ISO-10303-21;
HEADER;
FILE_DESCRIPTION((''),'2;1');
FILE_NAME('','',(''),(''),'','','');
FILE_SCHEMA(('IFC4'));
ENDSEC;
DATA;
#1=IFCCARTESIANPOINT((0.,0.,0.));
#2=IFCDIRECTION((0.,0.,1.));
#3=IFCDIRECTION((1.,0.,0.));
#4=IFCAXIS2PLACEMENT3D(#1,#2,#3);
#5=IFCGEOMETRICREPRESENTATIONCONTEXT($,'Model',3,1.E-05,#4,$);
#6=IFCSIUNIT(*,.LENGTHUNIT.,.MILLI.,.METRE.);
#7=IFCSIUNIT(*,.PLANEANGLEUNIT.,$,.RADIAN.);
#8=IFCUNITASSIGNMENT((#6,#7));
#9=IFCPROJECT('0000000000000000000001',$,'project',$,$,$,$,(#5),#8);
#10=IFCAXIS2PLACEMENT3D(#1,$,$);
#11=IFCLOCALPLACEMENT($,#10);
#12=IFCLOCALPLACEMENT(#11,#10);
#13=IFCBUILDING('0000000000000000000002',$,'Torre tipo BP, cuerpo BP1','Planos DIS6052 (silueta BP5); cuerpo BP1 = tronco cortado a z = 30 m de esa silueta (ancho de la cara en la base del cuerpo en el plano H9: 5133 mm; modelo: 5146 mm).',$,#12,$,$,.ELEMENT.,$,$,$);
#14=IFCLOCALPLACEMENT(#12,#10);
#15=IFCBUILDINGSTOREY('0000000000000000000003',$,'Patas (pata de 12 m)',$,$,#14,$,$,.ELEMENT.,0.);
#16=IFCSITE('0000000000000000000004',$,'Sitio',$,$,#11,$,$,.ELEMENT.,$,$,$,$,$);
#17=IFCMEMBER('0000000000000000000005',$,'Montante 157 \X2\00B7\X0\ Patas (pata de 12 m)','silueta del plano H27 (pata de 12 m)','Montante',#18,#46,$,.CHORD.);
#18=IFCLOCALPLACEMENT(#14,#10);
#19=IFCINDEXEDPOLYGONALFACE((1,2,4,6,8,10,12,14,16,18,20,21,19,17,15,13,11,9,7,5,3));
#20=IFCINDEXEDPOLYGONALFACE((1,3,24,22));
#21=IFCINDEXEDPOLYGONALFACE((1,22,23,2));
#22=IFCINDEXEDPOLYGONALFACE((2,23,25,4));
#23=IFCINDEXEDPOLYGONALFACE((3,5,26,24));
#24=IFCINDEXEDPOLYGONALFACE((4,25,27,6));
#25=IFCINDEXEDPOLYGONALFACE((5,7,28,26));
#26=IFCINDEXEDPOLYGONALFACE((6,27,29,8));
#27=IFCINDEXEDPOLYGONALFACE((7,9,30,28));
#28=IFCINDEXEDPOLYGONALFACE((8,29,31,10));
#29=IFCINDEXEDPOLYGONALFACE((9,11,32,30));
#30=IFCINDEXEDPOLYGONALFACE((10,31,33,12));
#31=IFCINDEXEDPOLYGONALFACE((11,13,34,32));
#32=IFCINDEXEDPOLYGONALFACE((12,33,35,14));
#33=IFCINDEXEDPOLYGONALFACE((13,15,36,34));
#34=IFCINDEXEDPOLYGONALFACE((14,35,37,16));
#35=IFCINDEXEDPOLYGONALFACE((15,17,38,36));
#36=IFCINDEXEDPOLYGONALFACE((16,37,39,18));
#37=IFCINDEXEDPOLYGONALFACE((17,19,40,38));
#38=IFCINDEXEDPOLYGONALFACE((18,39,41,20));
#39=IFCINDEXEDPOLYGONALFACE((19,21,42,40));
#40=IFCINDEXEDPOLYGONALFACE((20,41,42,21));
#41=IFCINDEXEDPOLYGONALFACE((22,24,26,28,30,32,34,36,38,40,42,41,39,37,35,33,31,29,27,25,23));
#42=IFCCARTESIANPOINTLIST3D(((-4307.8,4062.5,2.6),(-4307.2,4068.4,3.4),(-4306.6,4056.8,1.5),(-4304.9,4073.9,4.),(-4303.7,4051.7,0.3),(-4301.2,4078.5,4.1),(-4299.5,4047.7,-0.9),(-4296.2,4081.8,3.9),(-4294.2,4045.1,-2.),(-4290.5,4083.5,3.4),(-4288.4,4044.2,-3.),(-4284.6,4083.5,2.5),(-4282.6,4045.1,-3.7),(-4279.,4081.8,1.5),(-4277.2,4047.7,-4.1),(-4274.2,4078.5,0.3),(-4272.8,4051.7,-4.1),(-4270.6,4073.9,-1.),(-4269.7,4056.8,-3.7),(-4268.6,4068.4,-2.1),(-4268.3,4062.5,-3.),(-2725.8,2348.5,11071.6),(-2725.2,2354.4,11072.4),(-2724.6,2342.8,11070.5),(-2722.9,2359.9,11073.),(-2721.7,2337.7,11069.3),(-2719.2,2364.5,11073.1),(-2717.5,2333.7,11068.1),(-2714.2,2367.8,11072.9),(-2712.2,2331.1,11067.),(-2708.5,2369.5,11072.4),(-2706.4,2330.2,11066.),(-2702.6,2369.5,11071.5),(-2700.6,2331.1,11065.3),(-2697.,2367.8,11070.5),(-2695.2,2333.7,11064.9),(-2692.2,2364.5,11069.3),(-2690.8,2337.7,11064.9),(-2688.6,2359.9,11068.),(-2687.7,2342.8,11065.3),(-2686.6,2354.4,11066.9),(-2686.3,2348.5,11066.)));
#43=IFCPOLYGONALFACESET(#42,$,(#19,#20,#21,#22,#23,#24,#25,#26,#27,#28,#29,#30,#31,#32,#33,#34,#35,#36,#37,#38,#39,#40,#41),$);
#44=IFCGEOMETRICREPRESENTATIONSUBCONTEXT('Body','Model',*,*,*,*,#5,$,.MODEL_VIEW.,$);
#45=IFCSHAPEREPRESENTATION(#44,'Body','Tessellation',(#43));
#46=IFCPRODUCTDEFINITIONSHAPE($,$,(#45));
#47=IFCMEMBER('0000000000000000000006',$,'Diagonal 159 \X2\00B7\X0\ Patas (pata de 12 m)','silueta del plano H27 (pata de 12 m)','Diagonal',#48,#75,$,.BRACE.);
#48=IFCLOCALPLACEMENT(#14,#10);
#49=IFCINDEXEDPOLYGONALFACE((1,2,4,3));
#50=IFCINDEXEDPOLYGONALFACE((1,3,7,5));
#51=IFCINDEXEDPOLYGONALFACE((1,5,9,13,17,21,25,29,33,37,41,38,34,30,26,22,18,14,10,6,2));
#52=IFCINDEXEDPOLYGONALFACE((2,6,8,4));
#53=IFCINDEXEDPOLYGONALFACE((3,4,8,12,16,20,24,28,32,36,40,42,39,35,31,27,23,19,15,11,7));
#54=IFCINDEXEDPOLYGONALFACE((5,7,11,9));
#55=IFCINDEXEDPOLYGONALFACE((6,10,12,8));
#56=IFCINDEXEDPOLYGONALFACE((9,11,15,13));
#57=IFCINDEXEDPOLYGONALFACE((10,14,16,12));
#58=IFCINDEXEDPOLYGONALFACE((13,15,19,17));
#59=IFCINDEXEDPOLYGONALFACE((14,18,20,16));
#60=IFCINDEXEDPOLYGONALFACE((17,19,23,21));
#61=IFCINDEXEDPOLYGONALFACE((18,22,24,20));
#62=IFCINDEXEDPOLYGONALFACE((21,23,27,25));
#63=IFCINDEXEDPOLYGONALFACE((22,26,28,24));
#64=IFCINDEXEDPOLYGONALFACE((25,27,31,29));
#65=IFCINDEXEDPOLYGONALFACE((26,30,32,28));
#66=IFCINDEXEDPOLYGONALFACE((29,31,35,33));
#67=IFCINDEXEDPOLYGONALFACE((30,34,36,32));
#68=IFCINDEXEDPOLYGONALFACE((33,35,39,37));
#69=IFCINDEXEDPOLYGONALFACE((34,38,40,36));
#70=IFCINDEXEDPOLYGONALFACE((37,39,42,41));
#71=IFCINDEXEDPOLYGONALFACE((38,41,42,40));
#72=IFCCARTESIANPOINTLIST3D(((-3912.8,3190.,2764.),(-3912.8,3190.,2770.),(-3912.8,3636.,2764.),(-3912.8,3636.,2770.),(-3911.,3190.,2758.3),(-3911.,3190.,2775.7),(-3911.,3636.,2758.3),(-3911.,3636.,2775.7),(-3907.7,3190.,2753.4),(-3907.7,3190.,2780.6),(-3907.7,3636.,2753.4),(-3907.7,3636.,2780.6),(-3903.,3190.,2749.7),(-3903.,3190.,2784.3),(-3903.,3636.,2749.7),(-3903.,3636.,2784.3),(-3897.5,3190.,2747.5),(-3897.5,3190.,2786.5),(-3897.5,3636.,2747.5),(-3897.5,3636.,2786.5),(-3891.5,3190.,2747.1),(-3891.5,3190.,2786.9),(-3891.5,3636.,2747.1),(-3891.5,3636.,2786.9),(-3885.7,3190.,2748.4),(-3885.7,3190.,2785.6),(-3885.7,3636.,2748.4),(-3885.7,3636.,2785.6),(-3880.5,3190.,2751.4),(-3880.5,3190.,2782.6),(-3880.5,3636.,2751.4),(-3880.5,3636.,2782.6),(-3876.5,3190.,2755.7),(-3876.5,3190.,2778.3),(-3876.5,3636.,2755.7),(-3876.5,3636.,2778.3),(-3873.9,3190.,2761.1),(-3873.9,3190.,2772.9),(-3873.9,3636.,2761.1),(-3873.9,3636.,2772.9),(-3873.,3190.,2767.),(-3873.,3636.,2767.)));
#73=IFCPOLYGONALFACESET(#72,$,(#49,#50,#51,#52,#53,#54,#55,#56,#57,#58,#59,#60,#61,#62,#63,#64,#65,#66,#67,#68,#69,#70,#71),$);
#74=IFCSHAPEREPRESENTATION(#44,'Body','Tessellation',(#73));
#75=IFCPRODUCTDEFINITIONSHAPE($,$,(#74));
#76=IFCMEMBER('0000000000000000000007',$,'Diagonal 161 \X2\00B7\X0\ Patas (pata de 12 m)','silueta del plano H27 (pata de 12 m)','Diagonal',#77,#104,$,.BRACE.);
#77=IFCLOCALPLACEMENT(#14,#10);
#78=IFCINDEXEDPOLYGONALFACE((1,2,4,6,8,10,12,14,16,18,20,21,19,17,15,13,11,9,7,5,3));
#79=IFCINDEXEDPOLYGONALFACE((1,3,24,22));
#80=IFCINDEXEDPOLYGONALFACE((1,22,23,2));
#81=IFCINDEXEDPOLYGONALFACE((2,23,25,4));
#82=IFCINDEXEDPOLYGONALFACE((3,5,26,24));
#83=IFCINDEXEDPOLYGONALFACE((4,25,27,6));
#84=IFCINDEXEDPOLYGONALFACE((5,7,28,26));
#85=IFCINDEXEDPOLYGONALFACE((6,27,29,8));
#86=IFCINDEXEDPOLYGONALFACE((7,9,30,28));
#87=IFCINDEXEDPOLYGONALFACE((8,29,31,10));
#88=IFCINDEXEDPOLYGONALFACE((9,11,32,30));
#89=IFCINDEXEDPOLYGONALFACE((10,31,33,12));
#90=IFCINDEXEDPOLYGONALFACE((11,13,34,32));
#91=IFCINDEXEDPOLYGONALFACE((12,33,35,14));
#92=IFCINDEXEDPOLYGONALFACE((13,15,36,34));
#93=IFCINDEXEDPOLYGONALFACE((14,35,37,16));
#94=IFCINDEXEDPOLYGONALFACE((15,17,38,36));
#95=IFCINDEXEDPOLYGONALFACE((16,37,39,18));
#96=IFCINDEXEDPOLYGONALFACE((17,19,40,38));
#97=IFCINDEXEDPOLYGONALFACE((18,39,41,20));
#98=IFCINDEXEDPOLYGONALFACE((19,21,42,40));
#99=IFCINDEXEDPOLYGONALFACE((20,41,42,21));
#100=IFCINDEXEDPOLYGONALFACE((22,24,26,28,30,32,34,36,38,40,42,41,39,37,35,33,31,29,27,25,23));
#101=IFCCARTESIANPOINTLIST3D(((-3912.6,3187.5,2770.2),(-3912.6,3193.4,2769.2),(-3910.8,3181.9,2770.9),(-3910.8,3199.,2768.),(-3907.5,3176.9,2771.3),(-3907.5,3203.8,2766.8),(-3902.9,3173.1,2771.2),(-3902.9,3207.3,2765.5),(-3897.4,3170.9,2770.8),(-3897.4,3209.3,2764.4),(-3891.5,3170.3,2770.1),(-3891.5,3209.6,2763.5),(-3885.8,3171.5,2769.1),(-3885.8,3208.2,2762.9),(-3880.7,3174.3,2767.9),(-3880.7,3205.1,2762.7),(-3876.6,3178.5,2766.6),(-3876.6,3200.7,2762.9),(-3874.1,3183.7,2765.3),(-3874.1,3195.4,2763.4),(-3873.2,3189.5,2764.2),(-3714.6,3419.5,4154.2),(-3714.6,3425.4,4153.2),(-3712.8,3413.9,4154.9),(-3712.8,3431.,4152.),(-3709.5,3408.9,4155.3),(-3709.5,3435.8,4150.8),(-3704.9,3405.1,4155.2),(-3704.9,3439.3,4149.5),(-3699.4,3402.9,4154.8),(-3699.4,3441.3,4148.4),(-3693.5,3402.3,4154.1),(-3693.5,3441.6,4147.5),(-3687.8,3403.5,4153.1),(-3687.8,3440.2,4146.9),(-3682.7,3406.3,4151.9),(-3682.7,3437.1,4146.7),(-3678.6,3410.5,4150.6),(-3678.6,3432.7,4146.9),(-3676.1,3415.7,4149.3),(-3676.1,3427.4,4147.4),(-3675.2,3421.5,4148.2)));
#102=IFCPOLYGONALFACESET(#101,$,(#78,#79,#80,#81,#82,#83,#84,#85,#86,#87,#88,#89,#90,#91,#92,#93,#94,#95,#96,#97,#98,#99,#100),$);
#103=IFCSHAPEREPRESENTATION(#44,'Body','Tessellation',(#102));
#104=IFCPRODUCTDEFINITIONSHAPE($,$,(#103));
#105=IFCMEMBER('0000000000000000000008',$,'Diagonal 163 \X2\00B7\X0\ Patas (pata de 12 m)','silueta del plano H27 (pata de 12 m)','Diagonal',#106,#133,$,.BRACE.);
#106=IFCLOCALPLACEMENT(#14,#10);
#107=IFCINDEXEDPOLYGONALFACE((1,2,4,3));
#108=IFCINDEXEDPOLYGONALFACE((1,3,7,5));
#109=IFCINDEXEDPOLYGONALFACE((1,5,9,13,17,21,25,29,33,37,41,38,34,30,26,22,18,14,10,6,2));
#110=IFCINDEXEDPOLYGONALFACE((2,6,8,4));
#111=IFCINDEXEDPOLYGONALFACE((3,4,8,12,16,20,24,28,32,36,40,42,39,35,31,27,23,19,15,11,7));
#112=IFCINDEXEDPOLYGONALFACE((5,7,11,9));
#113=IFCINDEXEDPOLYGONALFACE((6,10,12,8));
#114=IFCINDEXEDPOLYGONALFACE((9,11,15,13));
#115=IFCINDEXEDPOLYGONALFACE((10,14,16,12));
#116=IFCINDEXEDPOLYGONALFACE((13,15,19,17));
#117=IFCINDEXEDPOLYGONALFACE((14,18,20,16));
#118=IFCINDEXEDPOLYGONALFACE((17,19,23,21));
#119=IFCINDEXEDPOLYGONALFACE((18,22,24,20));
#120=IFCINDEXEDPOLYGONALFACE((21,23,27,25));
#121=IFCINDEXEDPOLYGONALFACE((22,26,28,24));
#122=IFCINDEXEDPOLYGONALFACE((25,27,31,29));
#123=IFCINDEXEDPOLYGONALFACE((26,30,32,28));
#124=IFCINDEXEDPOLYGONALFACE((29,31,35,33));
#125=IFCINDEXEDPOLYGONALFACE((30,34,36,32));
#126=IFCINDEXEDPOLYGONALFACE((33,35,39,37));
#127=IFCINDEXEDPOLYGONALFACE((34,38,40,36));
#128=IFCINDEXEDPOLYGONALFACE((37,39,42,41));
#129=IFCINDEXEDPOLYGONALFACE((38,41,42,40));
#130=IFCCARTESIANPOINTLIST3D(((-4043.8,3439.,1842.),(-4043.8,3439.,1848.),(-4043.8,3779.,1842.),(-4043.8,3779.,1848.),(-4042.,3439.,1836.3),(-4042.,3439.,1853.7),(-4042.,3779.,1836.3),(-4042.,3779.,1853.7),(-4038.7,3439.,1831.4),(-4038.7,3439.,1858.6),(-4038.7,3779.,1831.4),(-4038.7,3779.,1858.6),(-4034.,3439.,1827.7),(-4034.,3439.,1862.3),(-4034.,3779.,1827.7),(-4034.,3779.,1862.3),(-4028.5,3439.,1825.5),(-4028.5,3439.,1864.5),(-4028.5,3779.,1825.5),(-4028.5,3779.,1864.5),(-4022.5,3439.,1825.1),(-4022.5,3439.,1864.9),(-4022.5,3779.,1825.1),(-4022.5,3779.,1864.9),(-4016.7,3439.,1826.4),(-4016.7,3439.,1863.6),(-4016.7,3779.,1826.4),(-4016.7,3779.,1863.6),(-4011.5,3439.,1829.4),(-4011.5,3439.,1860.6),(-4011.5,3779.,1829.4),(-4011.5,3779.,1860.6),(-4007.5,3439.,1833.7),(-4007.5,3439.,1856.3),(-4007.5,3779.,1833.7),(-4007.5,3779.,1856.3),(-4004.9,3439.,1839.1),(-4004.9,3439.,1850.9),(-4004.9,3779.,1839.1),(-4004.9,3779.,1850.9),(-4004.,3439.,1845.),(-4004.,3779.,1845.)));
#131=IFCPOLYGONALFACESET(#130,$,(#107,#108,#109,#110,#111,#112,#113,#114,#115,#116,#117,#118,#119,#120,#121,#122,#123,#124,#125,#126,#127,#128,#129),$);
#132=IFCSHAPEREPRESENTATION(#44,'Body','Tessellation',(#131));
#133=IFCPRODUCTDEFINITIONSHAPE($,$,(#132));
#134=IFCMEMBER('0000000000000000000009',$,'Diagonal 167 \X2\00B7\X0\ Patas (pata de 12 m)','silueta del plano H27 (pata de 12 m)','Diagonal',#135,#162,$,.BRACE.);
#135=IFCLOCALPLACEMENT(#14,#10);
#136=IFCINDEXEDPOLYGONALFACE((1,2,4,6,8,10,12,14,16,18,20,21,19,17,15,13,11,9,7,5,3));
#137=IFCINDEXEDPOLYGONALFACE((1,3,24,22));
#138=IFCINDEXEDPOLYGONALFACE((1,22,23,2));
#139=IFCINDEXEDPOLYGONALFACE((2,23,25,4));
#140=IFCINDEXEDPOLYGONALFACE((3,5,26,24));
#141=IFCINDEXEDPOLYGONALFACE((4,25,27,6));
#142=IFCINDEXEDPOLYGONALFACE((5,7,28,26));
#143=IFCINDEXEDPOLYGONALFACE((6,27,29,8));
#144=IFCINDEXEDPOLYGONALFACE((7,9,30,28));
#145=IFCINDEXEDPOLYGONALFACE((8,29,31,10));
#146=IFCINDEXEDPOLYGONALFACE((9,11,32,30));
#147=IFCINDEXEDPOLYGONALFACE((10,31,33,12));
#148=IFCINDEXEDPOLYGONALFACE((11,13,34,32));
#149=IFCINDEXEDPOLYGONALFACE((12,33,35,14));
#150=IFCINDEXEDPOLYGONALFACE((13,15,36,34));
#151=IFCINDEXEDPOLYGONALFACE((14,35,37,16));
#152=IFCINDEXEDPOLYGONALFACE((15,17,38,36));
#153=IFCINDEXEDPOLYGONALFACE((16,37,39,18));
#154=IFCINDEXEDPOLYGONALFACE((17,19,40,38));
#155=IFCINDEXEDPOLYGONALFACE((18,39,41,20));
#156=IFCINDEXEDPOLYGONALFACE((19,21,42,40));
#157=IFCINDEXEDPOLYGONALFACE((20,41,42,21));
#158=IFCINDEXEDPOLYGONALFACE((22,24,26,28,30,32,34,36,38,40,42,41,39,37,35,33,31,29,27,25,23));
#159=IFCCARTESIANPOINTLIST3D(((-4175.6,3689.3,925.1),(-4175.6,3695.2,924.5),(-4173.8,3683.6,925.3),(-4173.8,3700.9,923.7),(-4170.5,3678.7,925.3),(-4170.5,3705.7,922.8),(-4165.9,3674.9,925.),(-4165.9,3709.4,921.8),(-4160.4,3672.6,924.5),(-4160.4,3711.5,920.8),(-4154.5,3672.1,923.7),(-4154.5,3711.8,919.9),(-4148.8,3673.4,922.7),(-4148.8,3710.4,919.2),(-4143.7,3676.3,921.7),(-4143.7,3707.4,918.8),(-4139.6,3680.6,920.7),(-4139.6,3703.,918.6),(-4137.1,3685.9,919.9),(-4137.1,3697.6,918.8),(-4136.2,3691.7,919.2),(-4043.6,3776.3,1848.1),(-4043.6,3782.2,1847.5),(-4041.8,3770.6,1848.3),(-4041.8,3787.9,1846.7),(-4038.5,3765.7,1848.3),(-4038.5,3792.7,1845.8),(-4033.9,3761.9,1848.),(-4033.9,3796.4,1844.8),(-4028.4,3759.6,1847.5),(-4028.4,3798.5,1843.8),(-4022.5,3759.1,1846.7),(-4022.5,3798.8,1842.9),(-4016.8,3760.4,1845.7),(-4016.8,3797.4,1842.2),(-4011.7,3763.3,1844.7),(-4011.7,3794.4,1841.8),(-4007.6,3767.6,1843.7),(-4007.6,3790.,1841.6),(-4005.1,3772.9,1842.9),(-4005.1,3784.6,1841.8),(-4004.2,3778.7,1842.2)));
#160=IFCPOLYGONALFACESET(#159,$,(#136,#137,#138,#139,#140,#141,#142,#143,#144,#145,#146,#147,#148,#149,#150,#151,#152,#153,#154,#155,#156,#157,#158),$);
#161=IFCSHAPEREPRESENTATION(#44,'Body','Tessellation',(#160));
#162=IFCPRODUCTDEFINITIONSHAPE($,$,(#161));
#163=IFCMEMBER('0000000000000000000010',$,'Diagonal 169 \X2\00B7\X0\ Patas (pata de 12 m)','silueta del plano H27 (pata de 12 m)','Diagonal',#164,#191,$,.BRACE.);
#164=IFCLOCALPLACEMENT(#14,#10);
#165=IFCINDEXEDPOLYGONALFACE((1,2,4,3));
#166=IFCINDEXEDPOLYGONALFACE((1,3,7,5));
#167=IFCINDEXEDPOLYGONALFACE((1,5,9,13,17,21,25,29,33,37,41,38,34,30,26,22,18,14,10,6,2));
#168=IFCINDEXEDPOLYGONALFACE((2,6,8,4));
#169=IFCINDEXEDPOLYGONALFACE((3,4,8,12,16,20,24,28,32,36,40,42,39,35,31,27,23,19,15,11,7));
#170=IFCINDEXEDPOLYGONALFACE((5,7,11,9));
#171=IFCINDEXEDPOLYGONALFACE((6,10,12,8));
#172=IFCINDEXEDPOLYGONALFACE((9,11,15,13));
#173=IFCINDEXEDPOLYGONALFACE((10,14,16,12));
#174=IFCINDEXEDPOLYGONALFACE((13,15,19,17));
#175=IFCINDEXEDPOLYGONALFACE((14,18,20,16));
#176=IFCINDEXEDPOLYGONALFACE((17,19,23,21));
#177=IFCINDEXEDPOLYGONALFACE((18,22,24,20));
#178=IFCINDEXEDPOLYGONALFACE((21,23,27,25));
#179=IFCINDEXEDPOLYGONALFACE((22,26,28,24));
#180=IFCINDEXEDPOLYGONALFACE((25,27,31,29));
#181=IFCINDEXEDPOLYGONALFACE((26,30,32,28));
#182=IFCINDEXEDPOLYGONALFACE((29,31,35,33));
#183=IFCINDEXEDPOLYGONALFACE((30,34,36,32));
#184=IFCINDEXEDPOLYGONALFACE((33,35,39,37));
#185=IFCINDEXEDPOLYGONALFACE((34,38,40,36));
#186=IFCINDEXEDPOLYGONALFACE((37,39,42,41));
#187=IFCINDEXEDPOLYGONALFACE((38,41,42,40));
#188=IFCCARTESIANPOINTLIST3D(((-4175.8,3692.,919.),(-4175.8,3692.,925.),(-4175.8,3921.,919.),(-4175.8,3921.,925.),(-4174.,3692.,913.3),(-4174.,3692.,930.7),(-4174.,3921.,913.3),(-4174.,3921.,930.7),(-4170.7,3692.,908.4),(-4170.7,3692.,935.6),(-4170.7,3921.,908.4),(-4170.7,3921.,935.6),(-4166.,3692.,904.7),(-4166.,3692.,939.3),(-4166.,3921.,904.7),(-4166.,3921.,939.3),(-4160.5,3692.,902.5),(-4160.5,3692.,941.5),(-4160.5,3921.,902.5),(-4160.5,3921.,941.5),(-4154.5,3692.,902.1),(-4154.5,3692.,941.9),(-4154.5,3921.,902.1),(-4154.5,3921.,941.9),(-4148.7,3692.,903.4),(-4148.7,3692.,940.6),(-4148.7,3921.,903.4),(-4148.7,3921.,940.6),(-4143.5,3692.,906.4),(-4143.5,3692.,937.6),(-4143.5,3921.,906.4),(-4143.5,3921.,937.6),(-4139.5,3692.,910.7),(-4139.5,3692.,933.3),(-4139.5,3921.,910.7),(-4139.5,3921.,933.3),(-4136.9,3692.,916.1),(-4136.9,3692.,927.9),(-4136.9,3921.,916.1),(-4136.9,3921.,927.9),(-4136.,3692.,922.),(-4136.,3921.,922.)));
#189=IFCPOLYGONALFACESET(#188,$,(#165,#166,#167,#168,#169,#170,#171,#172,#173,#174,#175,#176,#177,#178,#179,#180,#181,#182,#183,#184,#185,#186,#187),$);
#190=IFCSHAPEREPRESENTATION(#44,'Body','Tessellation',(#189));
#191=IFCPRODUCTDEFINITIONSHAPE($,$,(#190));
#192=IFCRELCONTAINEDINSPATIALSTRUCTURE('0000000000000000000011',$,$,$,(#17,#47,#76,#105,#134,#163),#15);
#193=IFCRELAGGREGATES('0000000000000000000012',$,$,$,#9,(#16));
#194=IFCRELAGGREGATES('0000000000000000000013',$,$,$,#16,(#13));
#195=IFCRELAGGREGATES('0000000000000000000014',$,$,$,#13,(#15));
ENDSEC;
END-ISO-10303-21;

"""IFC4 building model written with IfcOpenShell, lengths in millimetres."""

from ifc_helpers import new_model, si_unit, frame, origin, origin_with_axes, place, context, subcontext, project, spatial, circle, extrude, element, save


model = new_model("IFC4")

# Units and contexts
model_context = context("Model", 3, precision=1e-05, world=origin_with_axes())
body_context = subcontext(model_context, "Body", "Model", "MODEL_VIEW")
ifc_project = project(units=[si_unit("LENGTHUNIT", "METRE", prefix="MILLI"), si_unit("PLANEANGLEUNIT", "RADIAN")], contexts=[model_context])

# Site, building, storey
site_placement = place(None, origin())
site = spatial("IfcSite", under=ifc_project, at=site_placement, Name="Sitio", CompositionType="ELEMENT")
building_placement = place(site_placement, origin())
building = spatial("IfcBuilding", under=site, at=building_placement, Name="Torre tipo BP, cuerpo BP1", Description="Planos DIS6052 (silueta BP5); cuerpo BP1 = tronco cortado a z = 30 m de esa silueta (ancho de la cara en la base del cuerpo en el plano H9: 5133 mm; modelo: 5146 mm).", CompositionType="ELEMENT")
storey_placement = place(building_placement, origin())
storey = spatial("IfcBuildingStorey", under=building, at=storey_placement, Name="Patas (pata de 12 m)", CompositionType="ELEMENT", Elevation=0.0)

# Members
member_1_placement = place(storey_placement, frame((-4288.0, 4064.0, 0.0), z_axis=(0.13985, -0.151519, 0.978511), x_axis=(-0.021438, -0.988454, -0.149995)))
element("IfcMember", 1, at=member_1_placement, inside=storey, Name="Montante 157 · Patas (pata de 12 m)", Description="silueta del plano H27 (pata de 12 m)", ObjectType="Montante", PredefinedType="CHORD", context=body_context, shape_type="SweptSolid", body=[
    extrude(circle(Radius=20.0), None, (0.0, 0.0, 1.0), 11312.1),
])
member_2_placement = place(storey_placement, frame((-3893.0, 3636.0, 2767.0), z_axis=(0.0, -1.0, 0.0), x_axis=(1.0, 0.0, 0.0)))
element("IfcMember", 2, at=member_2_placement, inside=storey, Name="Diagonal 159 · Patas (pata de 12 m)", Description="silueta del plano H27 (pata de 12 m)", ObjectType="Diagonal", PredefinedType="BRACE", context=body_context, shape_type="SweptSolid", body=[
    extrude(circle(Radius=20.0), None, (0.0, 0.0, 1.0), 446.0),
])
member_3_placement = place(storey_placement, frame((-3893.0, 3190.0, 2767.0), z_axis=(0.139711, 0.163702, 0.976567), x_axis=(0.990192, -0.023098, -0.137789)))
element("IfcMember", 3, at=member_3_placement, inside=storey, Name="Diagonal 161 · Patas (pata de 12 m)", Description="silueta del plano H27 (pata de 12 m)", ObjectType="Diagonal", PredefinedType="BRACE", context=body_context, shape_type="SweptSolid", body=[
    extrude(circle(Radius=20.0), None, (0.0, 0.0, 1.0), 1417.2),
])
member_4_placement = place(storey_placement, frame((-4024.0, 3779.0, 1845.0), z_axis=(0.0, -1.0, 0.0), x_axis=(1.0, 0.0, 0.0)))
element("IfcMember", 4, at=member_4_placement, inside=storey, Name="Diagonal 163 · Patas (pata de 12 m)", Description="silueta del plano H27 (pata de 12 m)", ObjectType="Diagonal", PredefinedType="BRACE", context=body_context, shape_type="SweptSolid", body=[
    extrude(circle(Radius=20.0), None, (0.0, 0.0, 1.0), 340.0),
])
member_5_placement = place(storey_placement, frame((-4156.0, 3692.0, 922.0), z_axis=(0.140959, 0.092905, 0.985647), x_axis=(0.990015, -0.013228, -0.140337)))
element("IfcMember", 5, at=member_5_placement, inside=storey, Name="Diagonal 167 · Patas (pata de 12 m)", Description="silueta del plano H27 (pata de 12 m)", ObjectType="Diagonal", PredefinedType="BRACE", context=body_context, shape_type="SweptSolid", body=[
    extrude(circle(Radius=20.0), None, (0.0, 0.0, 1.0), 936.4),
])
member_6_placement = place(storey_placement, frame((-4156.0, 3921.0, 922.0), z_axis=(0.0, -1.0, 0.0), x_axis=(1.0, 0.0, 0.0)))
element("IfcMember", 6, at=member_6_placement, inside=storey, Name="Diagonal 169 · Patas (pata de 12 m)", Description="silueta del plano H27 (pata de 12 m)", ObjectType="Diagonal", PredefinedType="BRACE", context=body_context, shape_type="SweptSolid", body=[
    extrude(circle(Radius=20.0), None, (0.0, 0.0, 1.0), 229.0),
])

save(model, "model.ifc")
